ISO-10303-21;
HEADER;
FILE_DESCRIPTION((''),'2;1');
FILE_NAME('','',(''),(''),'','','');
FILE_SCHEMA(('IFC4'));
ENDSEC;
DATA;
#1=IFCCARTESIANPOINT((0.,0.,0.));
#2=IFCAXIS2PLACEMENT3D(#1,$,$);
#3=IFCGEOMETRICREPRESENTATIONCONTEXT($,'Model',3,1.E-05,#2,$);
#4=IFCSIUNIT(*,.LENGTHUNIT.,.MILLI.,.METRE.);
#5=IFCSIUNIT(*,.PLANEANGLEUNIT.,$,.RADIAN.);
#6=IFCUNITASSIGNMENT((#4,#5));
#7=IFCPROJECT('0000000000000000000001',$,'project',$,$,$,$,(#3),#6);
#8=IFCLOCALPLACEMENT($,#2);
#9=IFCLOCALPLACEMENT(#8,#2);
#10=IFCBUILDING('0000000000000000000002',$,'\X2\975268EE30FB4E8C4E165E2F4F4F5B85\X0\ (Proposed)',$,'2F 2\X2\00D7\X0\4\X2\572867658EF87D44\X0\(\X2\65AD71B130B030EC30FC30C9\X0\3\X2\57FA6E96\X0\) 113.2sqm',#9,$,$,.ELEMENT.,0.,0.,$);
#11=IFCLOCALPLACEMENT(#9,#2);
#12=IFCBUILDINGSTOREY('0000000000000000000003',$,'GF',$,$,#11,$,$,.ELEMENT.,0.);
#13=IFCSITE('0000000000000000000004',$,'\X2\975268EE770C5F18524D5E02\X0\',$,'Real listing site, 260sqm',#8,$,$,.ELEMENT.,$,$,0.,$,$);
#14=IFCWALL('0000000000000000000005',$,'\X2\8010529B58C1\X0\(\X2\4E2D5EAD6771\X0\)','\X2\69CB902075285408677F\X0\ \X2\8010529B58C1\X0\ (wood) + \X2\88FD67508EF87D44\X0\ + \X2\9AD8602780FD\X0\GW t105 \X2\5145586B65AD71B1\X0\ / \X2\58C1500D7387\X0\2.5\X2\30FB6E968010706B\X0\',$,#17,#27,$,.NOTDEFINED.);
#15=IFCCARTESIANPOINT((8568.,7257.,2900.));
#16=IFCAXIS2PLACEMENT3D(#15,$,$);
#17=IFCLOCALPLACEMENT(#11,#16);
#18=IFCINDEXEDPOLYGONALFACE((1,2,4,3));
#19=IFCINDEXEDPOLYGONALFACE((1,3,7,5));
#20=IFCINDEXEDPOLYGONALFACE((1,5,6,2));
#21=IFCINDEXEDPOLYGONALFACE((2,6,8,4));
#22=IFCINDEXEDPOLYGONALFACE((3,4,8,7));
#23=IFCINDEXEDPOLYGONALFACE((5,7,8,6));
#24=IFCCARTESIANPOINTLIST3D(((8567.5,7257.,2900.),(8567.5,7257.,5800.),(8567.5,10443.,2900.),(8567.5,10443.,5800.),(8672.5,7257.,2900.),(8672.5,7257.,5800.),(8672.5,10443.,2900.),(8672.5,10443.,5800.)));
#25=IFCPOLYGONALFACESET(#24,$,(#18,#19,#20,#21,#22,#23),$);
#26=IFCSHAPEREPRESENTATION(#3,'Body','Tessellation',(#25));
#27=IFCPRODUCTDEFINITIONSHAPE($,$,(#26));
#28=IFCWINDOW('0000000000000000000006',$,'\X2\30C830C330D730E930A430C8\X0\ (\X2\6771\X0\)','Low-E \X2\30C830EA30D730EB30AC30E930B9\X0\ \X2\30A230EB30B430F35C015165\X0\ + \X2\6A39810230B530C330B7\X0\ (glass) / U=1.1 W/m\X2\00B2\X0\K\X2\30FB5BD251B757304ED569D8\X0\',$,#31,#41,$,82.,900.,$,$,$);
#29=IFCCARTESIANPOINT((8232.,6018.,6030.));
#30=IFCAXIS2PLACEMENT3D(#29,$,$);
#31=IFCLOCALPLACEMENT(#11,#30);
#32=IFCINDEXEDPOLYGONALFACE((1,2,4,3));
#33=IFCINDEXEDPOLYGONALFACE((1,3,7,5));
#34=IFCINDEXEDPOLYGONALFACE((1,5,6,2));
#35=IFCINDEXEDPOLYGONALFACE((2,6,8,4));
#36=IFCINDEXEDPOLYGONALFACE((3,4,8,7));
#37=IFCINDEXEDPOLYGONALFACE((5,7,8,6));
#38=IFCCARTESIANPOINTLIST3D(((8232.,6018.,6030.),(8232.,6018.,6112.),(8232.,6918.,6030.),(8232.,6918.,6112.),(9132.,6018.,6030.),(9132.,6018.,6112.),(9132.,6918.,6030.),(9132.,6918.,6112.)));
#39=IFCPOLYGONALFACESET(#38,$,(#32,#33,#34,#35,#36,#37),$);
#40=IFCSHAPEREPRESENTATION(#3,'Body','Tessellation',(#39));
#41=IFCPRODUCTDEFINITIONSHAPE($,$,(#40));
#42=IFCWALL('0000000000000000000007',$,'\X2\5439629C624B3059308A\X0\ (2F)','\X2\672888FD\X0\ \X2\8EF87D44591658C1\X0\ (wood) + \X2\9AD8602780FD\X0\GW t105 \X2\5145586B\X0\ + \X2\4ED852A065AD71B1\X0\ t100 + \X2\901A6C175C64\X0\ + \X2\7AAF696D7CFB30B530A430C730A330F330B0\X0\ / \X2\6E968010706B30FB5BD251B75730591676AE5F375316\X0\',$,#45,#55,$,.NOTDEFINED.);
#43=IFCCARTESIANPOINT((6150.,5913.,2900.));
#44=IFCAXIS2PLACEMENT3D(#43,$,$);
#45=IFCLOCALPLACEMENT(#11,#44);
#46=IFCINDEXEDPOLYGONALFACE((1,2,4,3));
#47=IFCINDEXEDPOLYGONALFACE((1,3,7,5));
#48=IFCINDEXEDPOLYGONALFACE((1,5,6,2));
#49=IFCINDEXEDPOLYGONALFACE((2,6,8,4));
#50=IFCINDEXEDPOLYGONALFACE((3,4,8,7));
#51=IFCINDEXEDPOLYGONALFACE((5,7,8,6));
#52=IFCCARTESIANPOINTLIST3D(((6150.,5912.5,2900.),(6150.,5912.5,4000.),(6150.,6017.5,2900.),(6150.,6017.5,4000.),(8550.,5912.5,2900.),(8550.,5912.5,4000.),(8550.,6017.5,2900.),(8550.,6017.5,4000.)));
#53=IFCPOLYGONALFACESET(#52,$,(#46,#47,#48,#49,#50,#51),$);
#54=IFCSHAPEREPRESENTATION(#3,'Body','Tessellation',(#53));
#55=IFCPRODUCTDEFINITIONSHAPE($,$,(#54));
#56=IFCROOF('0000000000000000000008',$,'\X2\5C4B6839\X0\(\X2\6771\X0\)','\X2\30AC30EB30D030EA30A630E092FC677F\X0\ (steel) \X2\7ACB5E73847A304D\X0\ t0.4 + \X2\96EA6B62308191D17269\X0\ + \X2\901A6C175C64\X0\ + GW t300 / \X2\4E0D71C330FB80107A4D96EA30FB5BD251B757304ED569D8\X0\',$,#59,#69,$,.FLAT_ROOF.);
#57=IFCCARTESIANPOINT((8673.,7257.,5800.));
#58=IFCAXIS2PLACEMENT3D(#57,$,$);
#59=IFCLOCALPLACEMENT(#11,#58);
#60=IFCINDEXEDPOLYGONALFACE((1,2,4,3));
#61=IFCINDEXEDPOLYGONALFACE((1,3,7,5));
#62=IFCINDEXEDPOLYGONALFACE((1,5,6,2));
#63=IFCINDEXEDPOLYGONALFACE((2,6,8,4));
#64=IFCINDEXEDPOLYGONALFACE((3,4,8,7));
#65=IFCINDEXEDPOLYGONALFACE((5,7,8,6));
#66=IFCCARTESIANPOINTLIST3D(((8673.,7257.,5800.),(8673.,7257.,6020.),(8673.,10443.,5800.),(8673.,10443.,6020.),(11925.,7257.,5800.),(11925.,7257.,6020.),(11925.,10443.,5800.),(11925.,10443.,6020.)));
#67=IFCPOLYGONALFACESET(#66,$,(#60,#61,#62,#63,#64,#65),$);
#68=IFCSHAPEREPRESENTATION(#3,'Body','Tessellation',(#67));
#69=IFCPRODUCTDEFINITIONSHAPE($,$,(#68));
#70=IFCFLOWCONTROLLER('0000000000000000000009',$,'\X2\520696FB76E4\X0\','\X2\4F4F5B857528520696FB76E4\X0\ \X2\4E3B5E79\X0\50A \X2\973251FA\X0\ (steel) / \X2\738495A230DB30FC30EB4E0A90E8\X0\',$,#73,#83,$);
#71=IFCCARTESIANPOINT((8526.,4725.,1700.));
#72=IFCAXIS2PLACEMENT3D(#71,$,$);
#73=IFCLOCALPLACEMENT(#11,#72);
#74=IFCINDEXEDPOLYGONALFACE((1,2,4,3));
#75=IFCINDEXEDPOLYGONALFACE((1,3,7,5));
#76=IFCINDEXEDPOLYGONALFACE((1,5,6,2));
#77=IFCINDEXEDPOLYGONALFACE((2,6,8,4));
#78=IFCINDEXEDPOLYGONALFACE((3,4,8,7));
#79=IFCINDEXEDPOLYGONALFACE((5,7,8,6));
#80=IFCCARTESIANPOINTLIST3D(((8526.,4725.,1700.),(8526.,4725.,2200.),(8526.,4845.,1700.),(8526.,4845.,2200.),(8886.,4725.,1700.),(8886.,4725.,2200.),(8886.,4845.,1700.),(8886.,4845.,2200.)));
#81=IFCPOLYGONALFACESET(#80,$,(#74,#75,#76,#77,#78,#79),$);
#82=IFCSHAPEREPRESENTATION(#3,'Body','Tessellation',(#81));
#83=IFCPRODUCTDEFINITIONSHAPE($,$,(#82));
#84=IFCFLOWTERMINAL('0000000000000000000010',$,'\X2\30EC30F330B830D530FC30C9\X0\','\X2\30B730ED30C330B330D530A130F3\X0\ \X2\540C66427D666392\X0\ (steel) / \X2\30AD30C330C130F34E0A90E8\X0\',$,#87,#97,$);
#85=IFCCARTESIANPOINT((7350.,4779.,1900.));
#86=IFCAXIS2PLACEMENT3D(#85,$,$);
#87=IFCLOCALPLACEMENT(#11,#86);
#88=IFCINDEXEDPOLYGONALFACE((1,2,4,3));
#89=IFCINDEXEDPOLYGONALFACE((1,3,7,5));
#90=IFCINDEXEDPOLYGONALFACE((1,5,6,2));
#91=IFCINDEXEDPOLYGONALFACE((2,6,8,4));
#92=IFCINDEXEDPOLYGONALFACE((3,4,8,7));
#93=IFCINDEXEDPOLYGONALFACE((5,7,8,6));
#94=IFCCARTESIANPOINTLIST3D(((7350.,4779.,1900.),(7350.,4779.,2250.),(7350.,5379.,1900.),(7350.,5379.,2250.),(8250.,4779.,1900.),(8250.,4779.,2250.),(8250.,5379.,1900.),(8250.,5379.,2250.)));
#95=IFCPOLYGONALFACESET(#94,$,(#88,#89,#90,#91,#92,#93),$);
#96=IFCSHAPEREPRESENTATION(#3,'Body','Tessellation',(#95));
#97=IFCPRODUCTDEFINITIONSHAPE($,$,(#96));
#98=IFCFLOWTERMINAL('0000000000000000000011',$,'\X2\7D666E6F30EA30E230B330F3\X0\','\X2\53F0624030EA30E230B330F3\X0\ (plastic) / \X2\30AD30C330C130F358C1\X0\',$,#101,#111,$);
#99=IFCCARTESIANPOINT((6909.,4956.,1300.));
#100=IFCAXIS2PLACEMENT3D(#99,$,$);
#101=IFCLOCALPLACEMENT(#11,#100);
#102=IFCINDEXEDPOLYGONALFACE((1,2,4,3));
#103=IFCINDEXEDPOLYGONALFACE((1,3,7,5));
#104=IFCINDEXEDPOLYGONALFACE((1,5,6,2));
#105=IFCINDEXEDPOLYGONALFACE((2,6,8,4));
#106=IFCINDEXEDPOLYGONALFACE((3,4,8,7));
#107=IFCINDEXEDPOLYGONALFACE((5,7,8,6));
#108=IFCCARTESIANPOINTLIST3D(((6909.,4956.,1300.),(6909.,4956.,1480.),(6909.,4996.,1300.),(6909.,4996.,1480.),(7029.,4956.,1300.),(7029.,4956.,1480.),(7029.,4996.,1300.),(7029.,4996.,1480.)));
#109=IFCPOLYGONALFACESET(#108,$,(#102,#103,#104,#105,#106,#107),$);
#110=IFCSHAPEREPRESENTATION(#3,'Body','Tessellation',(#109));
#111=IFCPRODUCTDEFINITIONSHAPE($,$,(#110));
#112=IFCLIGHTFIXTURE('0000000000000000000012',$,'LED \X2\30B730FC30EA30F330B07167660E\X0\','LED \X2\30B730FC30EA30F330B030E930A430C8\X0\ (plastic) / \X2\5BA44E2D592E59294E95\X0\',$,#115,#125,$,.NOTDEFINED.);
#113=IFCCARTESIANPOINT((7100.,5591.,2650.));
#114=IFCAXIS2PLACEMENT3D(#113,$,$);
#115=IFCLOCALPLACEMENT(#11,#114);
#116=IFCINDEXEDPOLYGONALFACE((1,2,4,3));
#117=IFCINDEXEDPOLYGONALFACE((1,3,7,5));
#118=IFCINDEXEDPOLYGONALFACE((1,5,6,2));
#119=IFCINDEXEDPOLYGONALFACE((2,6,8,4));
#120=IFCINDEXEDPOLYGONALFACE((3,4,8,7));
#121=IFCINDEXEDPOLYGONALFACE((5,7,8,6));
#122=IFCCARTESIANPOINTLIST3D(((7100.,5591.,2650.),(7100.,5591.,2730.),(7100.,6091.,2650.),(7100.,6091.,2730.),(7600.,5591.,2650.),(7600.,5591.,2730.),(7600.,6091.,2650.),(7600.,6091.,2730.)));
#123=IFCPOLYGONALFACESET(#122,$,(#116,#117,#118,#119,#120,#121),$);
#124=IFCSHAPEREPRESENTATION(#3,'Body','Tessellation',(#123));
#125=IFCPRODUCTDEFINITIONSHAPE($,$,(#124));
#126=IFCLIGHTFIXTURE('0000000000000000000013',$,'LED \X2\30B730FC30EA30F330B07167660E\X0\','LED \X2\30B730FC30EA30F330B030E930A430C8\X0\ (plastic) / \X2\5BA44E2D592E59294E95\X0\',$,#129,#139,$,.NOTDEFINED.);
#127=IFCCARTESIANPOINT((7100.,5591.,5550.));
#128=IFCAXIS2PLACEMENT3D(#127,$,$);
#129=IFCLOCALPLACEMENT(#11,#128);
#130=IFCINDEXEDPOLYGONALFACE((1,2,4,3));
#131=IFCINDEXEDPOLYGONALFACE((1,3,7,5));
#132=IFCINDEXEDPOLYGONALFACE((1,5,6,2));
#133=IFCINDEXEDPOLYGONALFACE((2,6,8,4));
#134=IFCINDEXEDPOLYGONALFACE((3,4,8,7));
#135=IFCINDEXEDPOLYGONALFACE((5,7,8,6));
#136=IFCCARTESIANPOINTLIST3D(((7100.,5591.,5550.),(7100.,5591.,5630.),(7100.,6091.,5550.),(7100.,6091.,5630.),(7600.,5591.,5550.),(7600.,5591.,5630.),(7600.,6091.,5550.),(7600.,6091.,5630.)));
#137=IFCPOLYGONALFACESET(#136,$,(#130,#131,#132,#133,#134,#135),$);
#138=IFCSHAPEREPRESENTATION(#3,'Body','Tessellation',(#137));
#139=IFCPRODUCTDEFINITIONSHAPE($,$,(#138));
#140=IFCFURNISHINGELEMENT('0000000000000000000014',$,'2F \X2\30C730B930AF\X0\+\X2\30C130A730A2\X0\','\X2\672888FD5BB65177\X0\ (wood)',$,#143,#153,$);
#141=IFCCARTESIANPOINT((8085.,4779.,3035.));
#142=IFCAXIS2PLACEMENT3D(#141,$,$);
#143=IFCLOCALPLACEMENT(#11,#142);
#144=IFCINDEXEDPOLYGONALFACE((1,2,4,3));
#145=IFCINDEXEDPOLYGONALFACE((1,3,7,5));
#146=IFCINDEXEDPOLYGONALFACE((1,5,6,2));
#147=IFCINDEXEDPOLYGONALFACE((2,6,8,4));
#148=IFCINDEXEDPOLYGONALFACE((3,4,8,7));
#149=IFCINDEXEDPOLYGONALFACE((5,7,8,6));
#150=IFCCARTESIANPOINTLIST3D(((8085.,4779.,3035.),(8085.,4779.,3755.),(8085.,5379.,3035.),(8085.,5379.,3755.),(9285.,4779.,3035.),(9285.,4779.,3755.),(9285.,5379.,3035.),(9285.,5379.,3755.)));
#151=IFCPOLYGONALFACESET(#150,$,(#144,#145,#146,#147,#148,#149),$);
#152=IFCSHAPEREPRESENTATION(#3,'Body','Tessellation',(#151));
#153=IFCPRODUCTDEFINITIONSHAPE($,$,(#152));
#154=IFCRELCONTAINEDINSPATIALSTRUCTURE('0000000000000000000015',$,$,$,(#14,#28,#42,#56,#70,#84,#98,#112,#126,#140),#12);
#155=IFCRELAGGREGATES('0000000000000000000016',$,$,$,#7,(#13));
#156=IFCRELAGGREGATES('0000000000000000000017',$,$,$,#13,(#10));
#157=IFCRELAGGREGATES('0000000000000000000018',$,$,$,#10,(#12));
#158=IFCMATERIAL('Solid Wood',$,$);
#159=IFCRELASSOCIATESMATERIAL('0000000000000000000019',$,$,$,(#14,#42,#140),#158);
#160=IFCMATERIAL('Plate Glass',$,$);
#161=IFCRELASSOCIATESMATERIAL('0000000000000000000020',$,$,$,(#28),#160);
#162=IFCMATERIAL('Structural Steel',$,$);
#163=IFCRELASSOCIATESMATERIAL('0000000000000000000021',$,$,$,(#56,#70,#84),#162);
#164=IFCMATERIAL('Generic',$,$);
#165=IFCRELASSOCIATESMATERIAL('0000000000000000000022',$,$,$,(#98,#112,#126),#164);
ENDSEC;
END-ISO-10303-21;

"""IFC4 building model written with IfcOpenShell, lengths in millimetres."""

from ifc_helpers import new_model, si_unit, frame, frame_2d, origin, place, context, project, spatial, rectangle, extrude, material, element, save


model = new_model("IFC4")

# Units and contexts
model_context = context("Model", 3, precision=1e-05, world=origin())
ifc_project = project(units=[si_unit("LENGTHUNIT", "METRE", prefix="MILLI"), si_unit("PLANEANGLEUNIT", "RADIAN")], contexts=[model_context])

# Site, building, storey
site_placement = place(None, origin())
site = spatial("IfcSite", under=ifc_project, at=site_placement, Name="青森県弘前市", ObjectType="Real listing site, 260sqm", CompositionType="ELEMENT", RefElevation=0.0)
building_placement = place(site_placement, origin())
building = spatial("IfcBuilding", under=site, at=building_placement, Name="青森・二世帯住宅 (Proposed)", ObjectType="2F 2×4在来軸組(断熱グレード3基準) 113.2sqm", CompositionType="ELEMENT", ElevationOfRefHeight=0.0, ElevationOfTerrain=0.0)
storey_placement = place(building_placement, origin())
storey = spatial("IfcBuildingStorey", under=building, at=storey_placement, Name="GF", CompositionType="ELEMENT", Elevation=0.0)

# Shared definitions
ifc_material_1 = material(Name="Solid Wood")

# Shared definitions
ifc_material_2 = material(Name="Plate Glass")

# Wall
wall_1_placement = place(storey_placement, frame((8568.0, 7257.0, 2900.0)))
element("IfcWall", 1, at=wall_1_placement, inside=storey, material=ifc_material_1, Name="耐力壁(中庭東)", Description="構造用合板 耐力壁 (wood) + 製材軸組 + 高性能GW t105 充填断熱 / 壁倍率2.5・準耐火", PredefinedType="NOTDEFINED", context=model_context, shape_type="SweptSolid", body=[
    extrude(rectangle(XDim=105.0, YDim=3186.0, at=frame_2d((52.0, 1593.0))), frame((8568.0, 7257.0, 2900.0)), (0.0, 0.0, 1.0), 2900.0),
])

# Window
window_1_placement = place(storey_placement, frame((8232.0, 6018.0, 6030.0)))
element("IfcWindow", 2, at=window_1_placement, inside=storey, material=ifc_material_2, Name="トップライト (東)", Description="Low-E トリプルガラス アルゴン封入 + 樹脂サッシ (glass) / U=1.1 W/m²K・寒冷地仕様", OverallHeight=82.0, OverallWidth=900.0, context=model_context, shape_type="SweptSolid", body=[
    extrude(rectangle(XDim=900.0, YDim=900.0, at=frame_2d((450.0, 450.0))), frame((8232.0, 6018.0, 6030.0)), (0.0, 0.0, 1.0), 82.0),
])

# Wall
wall_2_placement = place(storey_placement, frame((6150.0, 5913.0, 2900.0)))
element("IfcWall", 3, at=wall_2_placement, inside=storey, material=ifc_material_1, Name="吹抜手すり (2F)", Description="木製 軸組外壁 (wood) + 高性能GW t105 充填 + 付加断熱 t100 + 通気層 + 窯業系サイディング / 準耐火・寒冷地外皮強化", PredefinedType="NOTDEFINED", context=model_context, shape_type="SweptSolid", body=[
    extrude(rectangle(XDim=2400.0, YDim=105.0, at=frame_2d((1200.0, 52.0))), frame((6150.0, 5913.0, 2900.0)), (0.0, 0.0, 1.0), 1100.0),
])

# Roof
ifc_material_3 = material(Name="Structural Steel")
for number, where, name in (
    (4, (8673.0, 7257.0, 5800.0), "屋根(東)"),
):
    element("IfcRoof", number, at=place(storey_placement, frame(where)), inside=storey, material=ifc_material_3, Name=name, Description="ガルバリウム鋼板 (steel) 立平葺き t0.4 + 雪止め金物 + 通気層 + GW t300 / 不燃・耐積雪・寒冷地仕様", PredefinedType="FLAT_ROOF", context=model_context, shape_type="SweptSolid", body=[
        extrude(rectangle(XDim=3252.0, YDim=3186.0, at=frame_2d((1626.0, 1593.0))), frame((8673.0, 7257.0, 5800.0)), (0.0, 0.0, 1.0), 220.0),
    ])

# Flow controller
flow_controller_placement = place(storey_placement, frame((8526.0, 4725.0, 1700.0)))
element("IfcFlowController", 5, at=flow_controller_placement, inside=storey, material=ifc_material_3, Name="分電盤", Description="住宅用分電盤 主幹50A 露出 (steel) / 玄関ホール上部", context=model_context, shape_type="SweptSolid", body=[
    extrude(rectangle(XDim=360.0, YDim=120.0, at=frame_2d((180.0, 60.0))), frame((8526.0, 4725.0, 1700.0)), (0.0, 0.0, 1.0), 500.0),
])

# Flow terminals
flow_terminal_1_placement = place(storey_placement, frame((7350.0, 4779.0, 1900.0)))
element("IfcFlowTerminal", 6, at=flow_terminal_1_placement, inside=storey, material=ifc_material_3, Name="レンジフード", Description="シロッコファン 同時給排 (steel) / キッチン上部", context=model_context, shape_type="SweptSolid", body=[
    extrude(rectangle(XDim=900.0, YDim=600.0, at=frame_2d((450.0, 300.0))), frame((7350.0, 4779.0, 1900.0)), (0.0, 0.0, 1.0), 350.0),
])
ifc_material_4 = material(Name="Generic")
flow_terminal_2_placement = place(storey_placement, frame((6909.0, 4956.0, 1300.0)))
element("IfcFlowTerminal", 7, at=flow_terminal_2_placement, inside=storey, material=ifc_material_4, Name="給湯リモコン", Description="台所リモコン (plastic) / キッチン壁", context=model_context, shape_type="SweptSolid", body=[
    extrude(rectangle(XDim=120.0, YDim=40.0, at=frame_2d((60.0, 20.0))), frame((6909.0, 4956.0, 1300.0)), (0.0, 0.0, 1.0), 180.0),
])

# Light fixtures
light_fixture_1_placement = place(storey_placement, frame((7100.0, 5591.0, 2650.0)))
element("IfcLightFixture", 8, at=light_fixture_1_placement, inside=storey, material=ifc_material_4, Name="LED シーリング照明", Description="LED シーリングライト (plastic) / 室中央天井", PredefinedType="NOTDEFINED", context=model_context, shape_type="SweptSolid", body=[
    extrude(rectangle(XDim=500.0, YDim=500.0, at=frame_2d((250.0, 250.0))), frame((7100.0, 5591.0, 2650.0)), (0.0, 0.0, 1.0), 80.0),
])
light_fixture_2_placement = place(storey_placement, frame((7100.0, 5591.0, 5550.0)))
element("IfcLightFixture", 9, at=light_fixture_2_placement, inside=storey, material=ifc_material_4, Name="LED シーリング照明", Description="LED シーリングライト (plastic) / 室中央天井", PredefinedType="NOTDEFINED", context=model_context, shape_type="SweptSolid", body=[
    extrude(rectangle(XDim=500.0, YDim=500.0, at=frame_2d((250.0, 250.0))), frame((7100.0, 5591.0, 5550.0)), (0.0, 0.0, 1.0), 80.0),
])

# Furnishing element
furnishing_placement = place(storey_placement, frame((8085.0, 4779.0, 3035.0)))
element("IfcFurnishingElement", 10, at=furnishing_placement, inside=storey, material=ifc_material_1, Name="2F デスク+チェア", Description="木製家具 (wood)", context=model_context, shape_type="SweptSolid", body=[
    extrude(rectangle(XDim=1200.0, YDim=600.0, at=frame_2d((600.0, 300.0))), frame((8085.0, 4779.0, 3035.0)), (0.0, 0.0, 1.0), 720.0),
])

save(model, "model.ifc")
